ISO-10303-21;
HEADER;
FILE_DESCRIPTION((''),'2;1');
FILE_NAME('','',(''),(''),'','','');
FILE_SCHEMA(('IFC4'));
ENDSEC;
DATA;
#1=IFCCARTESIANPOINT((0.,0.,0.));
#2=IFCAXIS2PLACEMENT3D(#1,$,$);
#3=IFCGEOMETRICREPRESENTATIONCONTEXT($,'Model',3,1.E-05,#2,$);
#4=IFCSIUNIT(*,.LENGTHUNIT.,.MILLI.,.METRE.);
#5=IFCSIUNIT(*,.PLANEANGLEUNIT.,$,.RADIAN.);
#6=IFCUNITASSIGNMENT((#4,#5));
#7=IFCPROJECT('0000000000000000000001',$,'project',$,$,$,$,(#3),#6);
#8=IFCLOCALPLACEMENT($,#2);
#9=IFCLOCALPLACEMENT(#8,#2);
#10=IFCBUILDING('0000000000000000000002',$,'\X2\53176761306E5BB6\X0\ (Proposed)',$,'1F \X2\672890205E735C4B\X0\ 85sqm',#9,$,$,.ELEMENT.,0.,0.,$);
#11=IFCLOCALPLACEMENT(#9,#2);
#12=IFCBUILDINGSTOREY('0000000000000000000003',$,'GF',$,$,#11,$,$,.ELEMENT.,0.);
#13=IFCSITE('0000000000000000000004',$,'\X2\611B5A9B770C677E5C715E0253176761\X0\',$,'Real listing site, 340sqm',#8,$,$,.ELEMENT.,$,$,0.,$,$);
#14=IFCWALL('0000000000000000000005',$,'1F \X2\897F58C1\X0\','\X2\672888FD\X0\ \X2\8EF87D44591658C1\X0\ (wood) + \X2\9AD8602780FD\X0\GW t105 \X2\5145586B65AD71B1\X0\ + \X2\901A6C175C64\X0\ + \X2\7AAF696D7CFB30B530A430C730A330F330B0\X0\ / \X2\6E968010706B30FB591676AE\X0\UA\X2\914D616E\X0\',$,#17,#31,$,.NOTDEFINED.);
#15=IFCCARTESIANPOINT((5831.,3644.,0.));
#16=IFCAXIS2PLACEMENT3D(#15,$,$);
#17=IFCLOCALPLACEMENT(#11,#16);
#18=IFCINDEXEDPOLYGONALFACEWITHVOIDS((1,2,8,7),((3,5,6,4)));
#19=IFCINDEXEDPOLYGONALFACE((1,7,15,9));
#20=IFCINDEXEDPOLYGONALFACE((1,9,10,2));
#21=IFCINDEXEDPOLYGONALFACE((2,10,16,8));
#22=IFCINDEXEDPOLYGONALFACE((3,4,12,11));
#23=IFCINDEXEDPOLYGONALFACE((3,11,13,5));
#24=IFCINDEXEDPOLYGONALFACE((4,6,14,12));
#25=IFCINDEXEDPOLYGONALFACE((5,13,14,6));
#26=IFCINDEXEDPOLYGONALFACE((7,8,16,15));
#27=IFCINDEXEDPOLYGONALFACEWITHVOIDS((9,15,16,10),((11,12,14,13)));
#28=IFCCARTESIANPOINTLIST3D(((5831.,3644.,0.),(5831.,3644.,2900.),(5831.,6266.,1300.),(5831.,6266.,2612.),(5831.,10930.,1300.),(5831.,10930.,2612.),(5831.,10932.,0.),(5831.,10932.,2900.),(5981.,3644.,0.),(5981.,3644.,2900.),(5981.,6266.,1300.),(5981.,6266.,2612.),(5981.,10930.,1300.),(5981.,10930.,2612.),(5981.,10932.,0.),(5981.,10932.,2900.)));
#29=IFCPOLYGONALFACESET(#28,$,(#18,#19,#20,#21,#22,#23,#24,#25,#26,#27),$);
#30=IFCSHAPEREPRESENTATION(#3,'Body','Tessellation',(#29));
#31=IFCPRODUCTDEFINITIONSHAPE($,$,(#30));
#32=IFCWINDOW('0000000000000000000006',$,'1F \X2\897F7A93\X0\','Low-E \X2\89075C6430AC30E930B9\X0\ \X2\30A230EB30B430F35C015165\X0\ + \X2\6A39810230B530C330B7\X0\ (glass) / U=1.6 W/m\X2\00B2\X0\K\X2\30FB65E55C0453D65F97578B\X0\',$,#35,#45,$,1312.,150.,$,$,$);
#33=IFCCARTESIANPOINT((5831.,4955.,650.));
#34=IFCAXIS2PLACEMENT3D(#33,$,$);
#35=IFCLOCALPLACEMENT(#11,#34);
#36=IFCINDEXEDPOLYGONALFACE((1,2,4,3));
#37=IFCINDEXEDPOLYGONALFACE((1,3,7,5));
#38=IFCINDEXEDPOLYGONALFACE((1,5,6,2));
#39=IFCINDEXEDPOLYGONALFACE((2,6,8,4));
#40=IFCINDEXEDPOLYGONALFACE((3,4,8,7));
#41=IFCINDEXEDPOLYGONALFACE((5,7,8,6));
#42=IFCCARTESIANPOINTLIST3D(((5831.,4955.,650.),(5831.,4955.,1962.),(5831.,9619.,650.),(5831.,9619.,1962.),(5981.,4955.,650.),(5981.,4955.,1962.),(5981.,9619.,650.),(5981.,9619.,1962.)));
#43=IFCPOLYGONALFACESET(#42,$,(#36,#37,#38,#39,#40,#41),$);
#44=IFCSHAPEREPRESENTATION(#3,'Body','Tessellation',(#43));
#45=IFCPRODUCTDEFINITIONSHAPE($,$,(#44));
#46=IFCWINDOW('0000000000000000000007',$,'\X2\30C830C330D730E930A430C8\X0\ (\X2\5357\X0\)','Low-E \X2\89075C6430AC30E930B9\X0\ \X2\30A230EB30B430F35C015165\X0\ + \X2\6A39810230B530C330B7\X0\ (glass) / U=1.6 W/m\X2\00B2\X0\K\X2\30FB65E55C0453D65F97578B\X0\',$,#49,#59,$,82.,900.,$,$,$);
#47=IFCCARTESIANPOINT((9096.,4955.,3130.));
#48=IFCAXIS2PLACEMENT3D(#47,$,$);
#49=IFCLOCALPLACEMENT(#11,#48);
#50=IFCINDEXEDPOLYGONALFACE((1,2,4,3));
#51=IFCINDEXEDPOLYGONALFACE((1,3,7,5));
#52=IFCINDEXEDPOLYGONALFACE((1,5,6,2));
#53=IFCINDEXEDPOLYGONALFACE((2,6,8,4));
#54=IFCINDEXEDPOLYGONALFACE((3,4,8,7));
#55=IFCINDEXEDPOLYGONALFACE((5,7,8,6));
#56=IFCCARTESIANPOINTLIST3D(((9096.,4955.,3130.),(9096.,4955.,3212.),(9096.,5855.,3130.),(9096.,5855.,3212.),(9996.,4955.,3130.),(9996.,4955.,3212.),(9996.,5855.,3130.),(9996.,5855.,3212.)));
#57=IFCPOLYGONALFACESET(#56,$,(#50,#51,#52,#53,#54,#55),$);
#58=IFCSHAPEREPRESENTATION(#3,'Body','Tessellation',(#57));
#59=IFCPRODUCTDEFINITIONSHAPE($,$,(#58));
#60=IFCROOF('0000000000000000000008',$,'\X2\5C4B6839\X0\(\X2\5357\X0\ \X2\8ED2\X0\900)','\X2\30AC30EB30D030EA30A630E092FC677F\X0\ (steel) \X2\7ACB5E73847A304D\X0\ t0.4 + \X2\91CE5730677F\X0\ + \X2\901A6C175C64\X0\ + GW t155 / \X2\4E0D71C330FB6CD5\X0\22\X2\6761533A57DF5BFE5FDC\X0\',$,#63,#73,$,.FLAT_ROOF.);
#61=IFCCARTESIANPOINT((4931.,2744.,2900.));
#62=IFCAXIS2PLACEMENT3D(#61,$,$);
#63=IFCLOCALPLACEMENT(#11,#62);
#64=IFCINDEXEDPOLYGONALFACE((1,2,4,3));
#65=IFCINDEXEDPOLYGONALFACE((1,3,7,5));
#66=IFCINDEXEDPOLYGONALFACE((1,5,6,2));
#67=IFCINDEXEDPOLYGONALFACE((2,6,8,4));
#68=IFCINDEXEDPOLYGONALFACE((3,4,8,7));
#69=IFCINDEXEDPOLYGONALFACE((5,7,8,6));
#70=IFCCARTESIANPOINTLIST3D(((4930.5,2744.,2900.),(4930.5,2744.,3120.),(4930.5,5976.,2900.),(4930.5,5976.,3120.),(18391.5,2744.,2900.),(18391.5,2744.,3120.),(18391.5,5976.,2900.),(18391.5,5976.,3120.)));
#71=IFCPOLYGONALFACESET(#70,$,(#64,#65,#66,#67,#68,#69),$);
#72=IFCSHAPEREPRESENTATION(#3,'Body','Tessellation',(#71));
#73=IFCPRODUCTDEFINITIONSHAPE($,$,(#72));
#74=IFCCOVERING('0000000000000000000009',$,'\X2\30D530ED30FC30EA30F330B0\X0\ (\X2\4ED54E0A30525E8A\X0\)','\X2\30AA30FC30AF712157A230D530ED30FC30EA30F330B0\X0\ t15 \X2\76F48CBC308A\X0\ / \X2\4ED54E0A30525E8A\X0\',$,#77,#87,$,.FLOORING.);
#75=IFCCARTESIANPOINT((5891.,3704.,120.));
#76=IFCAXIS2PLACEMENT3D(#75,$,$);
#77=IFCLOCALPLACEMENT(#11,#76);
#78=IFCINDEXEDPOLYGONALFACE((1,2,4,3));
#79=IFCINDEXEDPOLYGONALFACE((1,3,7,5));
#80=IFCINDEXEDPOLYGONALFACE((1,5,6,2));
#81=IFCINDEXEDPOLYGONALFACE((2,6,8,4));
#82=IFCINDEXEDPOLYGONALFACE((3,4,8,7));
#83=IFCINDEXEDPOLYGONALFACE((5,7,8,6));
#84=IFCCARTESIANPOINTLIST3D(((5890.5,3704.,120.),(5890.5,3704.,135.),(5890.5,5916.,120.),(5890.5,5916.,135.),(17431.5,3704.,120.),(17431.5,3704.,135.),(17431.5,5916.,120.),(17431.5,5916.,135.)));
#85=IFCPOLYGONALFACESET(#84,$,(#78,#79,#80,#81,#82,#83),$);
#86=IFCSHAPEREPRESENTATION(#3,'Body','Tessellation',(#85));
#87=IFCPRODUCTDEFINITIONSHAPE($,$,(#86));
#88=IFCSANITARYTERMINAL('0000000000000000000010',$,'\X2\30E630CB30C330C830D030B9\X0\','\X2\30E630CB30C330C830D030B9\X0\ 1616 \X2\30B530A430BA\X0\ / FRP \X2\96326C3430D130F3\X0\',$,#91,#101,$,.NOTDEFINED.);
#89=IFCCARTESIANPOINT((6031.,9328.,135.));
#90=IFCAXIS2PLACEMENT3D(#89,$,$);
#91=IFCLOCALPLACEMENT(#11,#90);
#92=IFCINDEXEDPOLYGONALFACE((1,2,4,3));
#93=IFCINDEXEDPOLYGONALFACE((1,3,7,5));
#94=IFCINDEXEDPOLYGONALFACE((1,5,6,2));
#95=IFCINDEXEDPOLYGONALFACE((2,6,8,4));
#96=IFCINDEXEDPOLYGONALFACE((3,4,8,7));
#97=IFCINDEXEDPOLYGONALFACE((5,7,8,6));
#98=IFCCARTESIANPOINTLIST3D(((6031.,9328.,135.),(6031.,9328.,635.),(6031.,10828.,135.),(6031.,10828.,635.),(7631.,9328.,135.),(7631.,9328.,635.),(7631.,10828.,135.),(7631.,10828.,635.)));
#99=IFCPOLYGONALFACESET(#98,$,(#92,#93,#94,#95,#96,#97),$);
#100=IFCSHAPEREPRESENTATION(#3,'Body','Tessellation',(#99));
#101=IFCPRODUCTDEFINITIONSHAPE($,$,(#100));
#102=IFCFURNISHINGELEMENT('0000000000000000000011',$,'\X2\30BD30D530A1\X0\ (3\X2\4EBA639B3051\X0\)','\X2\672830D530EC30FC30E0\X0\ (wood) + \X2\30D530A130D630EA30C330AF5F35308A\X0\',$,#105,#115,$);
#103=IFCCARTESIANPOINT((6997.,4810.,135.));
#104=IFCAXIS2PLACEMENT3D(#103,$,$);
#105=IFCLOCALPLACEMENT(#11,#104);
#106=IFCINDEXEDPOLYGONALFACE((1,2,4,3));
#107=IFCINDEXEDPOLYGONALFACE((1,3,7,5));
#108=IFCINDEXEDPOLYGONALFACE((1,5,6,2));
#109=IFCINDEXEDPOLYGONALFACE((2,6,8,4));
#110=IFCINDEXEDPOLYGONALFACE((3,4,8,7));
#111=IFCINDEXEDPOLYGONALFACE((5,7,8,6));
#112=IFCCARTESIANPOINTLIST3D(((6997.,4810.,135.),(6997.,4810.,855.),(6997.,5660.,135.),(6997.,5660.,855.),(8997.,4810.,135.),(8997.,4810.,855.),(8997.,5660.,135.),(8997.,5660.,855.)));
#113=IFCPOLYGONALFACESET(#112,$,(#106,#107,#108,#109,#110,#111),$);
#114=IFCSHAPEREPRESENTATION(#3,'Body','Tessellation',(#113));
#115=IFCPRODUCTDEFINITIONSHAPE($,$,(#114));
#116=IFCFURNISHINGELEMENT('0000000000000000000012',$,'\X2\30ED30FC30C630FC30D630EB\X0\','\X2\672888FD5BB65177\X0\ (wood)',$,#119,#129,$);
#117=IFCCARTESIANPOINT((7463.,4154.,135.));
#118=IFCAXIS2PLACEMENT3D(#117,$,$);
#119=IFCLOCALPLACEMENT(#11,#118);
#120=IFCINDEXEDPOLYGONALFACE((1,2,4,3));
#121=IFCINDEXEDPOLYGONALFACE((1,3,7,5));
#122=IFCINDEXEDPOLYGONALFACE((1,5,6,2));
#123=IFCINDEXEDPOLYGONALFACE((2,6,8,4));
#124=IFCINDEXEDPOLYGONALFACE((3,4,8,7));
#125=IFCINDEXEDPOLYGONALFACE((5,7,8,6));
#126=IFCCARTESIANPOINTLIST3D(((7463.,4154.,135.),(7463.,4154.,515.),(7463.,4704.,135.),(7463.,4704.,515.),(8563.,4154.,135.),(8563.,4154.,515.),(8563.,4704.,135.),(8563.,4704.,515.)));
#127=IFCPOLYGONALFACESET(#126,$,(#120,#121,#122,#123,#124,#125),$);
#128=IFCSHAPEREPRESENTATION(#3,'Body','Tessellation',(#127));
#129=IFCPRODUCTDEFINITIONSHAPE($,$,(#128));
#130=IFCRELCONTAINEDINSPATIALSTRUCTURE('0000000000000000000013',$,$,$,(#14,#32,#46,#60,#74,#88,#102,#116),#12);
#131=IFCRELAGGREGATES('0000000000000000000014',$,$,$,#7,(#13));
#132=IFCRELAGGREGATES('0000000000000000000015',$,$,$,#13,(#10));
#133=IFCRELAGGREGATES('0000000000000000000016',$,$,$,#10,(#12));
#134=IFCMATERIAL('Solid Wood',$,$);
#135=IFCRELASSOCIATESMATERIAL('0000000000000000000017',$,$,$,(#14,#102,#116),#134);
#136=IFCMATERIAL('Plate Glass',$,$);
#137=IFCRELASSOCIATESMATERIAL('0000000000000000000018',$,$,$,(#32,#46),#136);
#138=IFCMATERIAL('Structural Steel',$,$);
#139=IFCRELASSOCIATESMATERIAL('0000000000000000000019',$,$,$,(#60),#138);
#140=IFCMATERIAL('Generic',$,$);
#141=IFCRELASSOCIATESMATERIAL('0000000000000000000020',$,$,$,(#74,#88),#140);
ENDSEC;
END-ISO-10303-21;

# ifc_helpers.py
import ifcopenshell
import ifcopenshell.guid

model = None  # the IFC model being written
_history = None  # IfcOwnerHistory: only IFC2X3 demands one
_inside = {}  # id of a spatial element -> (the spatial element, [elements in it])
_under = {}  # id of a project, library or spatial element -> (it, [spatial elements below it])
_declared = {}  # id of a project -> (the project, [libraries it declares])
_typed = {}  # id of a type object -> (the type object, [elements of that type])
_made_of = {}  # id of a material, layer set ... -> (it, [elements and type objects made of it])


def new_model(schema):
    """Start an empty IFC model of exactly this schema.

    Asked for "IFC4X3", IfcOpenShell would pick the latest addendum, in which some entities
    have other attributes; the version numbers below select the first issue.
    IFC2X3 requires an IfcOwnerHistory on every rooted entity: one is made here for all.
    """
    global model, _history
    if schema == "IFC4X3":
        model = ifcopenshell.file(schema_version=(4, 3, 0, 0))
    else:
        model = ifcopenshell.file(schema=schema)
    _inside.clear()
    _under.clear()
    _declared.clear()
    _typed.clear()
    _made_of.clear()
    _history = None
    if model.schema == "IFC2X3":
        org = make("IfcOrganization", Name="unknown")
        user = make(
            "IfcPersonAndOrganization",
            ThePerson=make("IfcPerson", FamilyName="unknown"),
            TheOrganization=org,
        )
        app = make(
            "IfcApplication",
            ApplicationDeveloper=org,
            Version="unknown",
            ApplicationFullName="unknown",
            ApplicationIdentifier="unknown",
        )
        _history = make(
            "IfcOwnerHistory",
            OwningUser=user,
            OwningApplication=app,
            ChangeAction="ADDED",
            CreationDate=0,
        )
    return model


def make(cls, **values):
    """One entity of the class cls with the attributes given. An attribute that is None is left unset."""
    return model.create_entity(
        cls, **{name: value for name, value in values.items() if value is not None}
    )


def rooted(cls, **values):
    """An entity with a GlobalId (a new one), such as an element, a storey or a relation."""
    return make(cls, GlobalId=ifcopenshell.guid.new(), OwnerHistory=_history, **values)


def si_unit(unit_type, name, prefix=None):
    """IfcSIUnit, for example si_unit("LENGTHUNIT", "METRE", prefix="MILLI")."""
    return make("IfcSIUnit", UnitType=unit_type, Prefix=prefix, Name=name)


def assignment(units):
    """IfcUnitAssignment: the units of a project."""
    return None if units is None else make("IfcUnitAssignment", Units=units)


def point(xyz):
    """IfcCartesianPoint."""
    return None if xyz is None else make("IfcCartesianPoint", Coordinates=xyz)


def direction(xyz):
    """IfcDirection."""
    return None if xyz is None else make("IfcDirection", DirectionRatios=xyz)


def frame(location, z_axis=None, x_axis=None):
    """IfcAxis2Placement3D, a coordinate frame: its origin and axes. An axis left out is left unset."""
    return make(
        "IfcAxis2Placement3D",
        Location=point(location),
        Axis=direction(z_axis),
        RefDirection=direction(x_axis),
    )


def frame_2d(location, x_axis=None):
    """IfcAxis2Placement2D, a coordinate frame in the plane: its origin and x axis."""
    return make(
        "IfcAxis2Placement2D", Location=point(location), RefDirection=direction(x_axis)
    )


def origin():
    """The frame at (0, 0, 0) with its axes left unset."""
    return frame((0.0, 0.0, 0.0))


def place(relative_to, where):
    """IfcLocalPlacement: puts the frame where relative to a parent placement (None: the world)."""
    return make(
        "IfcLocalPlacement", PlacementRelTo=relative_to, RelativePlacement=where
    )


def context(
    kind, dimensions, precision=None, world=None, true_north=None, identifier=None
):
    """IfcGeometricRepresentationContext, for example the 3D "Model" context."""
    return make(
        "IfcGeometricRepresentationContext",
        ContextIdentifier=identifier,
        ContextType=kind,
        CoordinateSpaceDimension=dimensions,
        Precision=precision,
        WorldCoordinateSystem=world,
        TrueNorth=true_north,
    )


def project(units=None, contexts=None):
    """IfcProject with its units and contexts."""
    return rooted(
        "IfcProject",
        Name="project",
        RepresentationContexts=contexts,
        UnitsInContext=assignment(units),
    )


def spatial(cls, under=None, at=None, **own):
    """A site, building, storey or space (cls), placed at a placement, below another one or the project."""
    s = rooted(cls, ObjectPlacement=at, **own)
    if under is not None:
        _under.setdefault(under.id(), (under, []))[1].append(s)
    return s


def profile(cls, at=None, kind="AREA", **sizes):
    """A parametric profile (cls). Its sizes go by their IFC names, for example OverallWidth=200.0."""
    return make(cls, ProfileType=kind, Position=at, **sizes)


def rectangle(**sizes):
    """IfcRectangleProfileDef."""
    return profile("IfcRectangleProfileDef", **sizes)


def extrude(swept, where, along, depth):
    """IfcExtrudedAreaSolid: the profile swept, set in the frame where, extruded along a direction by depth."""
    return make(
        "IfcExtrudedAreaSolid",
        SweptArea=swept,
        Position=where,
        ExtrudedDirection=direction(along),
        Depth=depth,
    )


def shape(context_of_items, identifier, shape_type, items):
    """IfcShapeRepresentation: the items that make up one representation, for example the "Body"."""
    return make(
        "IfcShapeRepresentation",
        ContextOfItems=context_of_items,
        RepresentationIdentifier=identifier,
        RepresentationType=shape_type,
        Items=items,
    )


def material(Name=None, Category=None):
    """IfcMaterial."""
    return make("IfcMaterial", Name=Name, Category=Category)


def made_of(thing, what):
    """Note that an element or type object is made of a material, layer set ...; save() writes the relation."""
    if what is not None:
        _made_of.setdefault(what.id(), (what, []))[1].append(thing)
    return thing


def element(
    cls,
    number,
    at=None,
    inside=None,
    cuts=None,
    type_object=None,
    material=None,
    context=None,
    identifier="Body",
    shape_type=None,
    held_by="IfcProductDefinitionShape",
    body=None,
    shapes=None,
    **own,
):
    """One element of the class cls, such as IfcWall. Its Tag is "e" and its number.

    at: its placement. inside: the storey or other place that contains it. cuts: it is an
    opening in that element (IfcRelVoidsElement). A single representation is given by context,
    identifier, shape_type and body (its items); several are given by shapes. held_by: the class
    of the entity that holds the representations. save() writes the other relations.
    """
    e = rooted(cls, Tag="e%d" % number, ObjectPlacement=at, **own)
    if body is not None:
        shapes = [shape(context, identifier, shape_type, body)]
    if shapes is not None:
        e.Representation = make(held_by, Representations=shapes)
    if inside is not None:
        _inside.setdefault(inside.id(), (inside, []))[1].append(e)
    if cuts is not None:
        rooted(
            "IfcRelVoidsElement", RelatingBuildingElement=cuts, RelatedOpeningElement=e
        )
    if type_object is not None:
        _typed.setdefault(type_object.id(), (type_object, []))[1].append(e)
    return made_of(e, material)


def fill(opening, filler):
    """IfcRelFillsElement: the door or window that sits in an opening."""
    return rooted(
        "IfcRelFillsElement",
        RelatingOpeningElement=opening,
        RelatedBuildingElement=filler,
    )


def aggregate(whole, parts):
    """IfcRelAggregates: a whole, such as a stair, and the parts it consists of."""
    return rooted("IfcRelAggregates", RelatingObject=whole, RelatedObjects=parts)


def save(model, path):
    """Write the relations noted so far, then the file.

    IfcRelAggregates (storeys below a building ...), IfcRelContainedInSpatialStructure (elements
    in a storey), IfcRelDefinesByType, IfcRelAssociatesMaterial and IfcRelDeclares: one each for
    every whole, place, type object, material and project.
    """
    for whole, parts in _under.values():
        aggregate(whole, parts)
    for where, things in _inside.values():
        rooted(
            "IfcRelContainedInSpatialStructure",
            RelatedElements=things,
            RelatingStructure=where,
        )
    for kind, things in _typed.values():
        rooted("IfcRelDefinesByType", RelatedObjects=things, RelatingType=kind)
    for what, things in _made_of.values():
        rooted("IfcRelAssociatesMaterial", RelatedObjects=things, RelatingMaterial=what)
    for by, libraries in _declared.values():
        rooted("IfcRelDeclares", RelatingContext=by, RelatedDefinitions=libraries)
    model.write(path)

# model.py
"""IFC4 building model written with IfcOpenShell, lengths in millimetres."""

from ifc_helpers import new_model, si_unit, frame, frame_2d, origin, place, context, project, spatial, rectangle, extrude, material, element, fill, save


model = new_model("IFC4")

# Units and contexts
model_context = context("Model", 3, precision=1e-05, world=origin())
ifc_project = project(units=[si_unit("LENGTHUNIT", "METRE", prefix="MILLI"), si_unit("PLANEANGLEUNIT", "RADIAN")], contexts=[model_context])

# Site, building, storey
site_placement = place(None, origin())
site = spatial("IfcSite", under=ifc_project, at=site_placement, Name="愛媛県松山市北条", ObjectType="Real listing site, 340sqm", CompositionType="ELEMENT", RefElevation=0.0)
building_placement = place(site_placement, origin())
building = spatial("IfcBuilding", under=site, at=building_placement, Name="北条の家 (Proposed)", ObjectType="1F 木造平屋 85sqm", CompositionType="ELEMENT", ElevationOfRefHeight=0.0, ElevationOfTerrain=0.0)
storey_placement = place(building_placement, origin())
storey = spatial("IfcBuildingStorey", under=building, at=storey_placement, Name="GF", CompositionType="ELEMENT", Elevation=0.0)

# Shared definitions
ifc_material_1 = material(Name="Solid Wood")

# Shared definitions
ifc_material_2 = material(Name="Plate Glass")

# Wall, opening, window
wall_1_placement = place(storey_placement, frame((5831.0, 3644.0, 0.0)))
wall_1 = element("IfcWall", 1, at=wall_1_placement, inside=storey, material=ifc_material_1, Name="1F 西壁", Description="木製 軸組外壁 (wood) + 高性能GW t105 充填断熱 + 通気層 + 窯業系サイディング / 準耐火・外皮UA配慮", PredefinedType="NOTDEFINED", context=model_context, shape_type="SweptSolid", body=[
    extrude(rectangle(XDim=150.0, YDim=7288.0, at=frame_2d((75.0, 3644.0))), frame((5831.0, 3644.0, 0.0)), (0.0, 0.0, 1.0), 2900.0),
])
opening_1_placement = place(storey_placement, frame((5831.0, 4955.0, 650.0)))
opening_1 = element("IfcOpeningElement", 2, at=opening_1_placement, cuts=wall_1, PredefinedType="NOTDEFINED", context=model_context, shape_type="SweptSolid", body=[
    extrude(rectangle(XDim=150.0, YDim=4664.0, at=frame_2d((75.0, 2332.0))), frame((5831.0, 4955.0, 650.0)), (0.0, 0.0, 1.0), 1312.0),
])
window_1_placement = place(storey_placement, frame((5831.0, 4955.0, 650.0)))
window_1 = element("IfcWindow", 3, at=window_1_placement, inside=storey, material=ifc_material_2, Name="1F 西窓", Description="Low-E 複層ガラス アルゴン封入 + 樹脂サッシ (glass) / U=1.6 W/m²K・日射取得型", OverallHeight=1312.0, OverallWidth=150.0, context=model_context, shape_type="SweptSolid", body=[
    extrude(rectangle(XDim=150.0, YDim=4664.0, at=frame_2d((75.0, 2332.0))), frame((5831.0, 4955.0, 650.0)), (0.0, 0.0, 1.0), 1312.0),
])
fill(opening_1, window_1)

# Window
window_2_placement = place(storey_placement, frame((9096.0, 4955.0, 3130.0)))
element("IfcWindow", 4, at=window_2_placement, inside=storey, material=ifc_material_2, Name="トップライト (南)", Description="Low-E 複層ガラス アルゴン封入 + 樹脂サッシ (glass) / U=1.6 W/m²K・日射取得型", OverallHeight=82.0, OverallWidth=900.0, context=model_context, shape_type="SweptSolid", body=[
    extrude(rectangle(XDim=900.0, YDim=900.0, at=frame_2d((450.0, 450.0))), frame((9096.0, 4955.0, 3130.0)), (0.0, 0.0, 1.0), 82.0),
])

# Roof
ifc_material_3 = material(Name="Structural Steel")
roof_1_placement = place(storey_placement, frame((4931.0, 2744.0, 2900.0)))
element("IfcRoof", 5, at=roof_1_placement, inside=storey, material=ifc_material_3, Name="屋根(南 軒900)", Description="ガルバリウム鋼板 (steel) 立平葺き t0.4 + 野地板 + 通気層 + GW t155 / 不燃・法22条区域対応", PredefinedType="FLAT_ROOF", context=model_context, shape_type="SweptSolid", body=[
    extrude(rectangle(XDim=13461.0, YDim=3232.0, at=frame_2d((6730.0, 1616.0))), frame((4931.0, 2744.0, 2900.0)), (0.0, 0.0, 1.0), 220.0),
])

# Covering
ifc_material_4 = material(Name="Generic")
covering_1_placement = place(storey_placement, frame((5891.0, 3704.0, 120.0)))
element("IfcCovering", 6, at=covering_1_placement, inside=storey, material=ifc_material_4, Name="フローリング (仕上げ床)", Description="オーク無垢フローリング t15 直貼り / 仕上げ床", PredefinedType="FLOORING", context=model_context, shape_type="SweptSolid", body=[
    extrude(rectangle(XDim=11541.0, YDim=2212.0, at=frame_2d((5770.0, 1106.0))), frame((5891.0, 3704.0, 120.0)), (0.0, 0.0, 1.0), 15.0),
])

# Sanitary terminal
sanitary_terminal_placement = place(storey_placement, frame((6031.0, 9328.0, 135.0)))
element("IfcSanitaryTerminal", 7, at=sanitary_terminal_placement, inside=storey, material=ifc_material_4, Name="ユニットバス", Description="ユニットバス 1616 サイズ / FRP 防水パン", PredefinedType="NOTDEFINED", context=model_context, shape_type="SweptSolid", body=[
    extrude(rectangle(XDim=1600.0, YDim=1500.0, at=frame_2d((800.0, 750.0))), frame((6031.0, 9328.0, 135.0)), (0.0, 0.0, 1.0), 500.0),
])

# Furnishing elements
furnishing_1_placement = place(storey_placement, frame((6997.0, 4810.0, 135.0)))
element("IfcFurnishingElement", 8, at=furnishing_1_placement, inside=storey, material=ifc_material_1, Name="ソファ (3人掛け)", Description="木フレーム (wood) + ファブリック張り", context=model_context, shape_type="SweptSolid", body=[
    extrude(rectangle(XDim=2000.0, YDim=850.0, at=frame_2d((1000.0, 425.0))), frame((6997.0, 4810.0, 135.0)), (0.0, 0.0, 1.0), 720.0),
])
furnishing_2_placement = place(storey_placement, frame((7463.0, 4154.0, 135.0)))
element("IfcFurnishingElement", 9, at=furnishing_2_placement, inside=storey, material=ifc_material_1, Name="ローテーブル", Description="木製家具 (wood)", context=model_context, shape_type="SweptSolid", body=[
    extrude(rectangle(XDim=1100.0, YDim=550.0, at=frame_2d((550.0, 275.0))), frame((7463.0, 4154.0, 135.0)), (0.0, 0.0, 1.0), 380.0),
])

save(model, "model.ifc")
